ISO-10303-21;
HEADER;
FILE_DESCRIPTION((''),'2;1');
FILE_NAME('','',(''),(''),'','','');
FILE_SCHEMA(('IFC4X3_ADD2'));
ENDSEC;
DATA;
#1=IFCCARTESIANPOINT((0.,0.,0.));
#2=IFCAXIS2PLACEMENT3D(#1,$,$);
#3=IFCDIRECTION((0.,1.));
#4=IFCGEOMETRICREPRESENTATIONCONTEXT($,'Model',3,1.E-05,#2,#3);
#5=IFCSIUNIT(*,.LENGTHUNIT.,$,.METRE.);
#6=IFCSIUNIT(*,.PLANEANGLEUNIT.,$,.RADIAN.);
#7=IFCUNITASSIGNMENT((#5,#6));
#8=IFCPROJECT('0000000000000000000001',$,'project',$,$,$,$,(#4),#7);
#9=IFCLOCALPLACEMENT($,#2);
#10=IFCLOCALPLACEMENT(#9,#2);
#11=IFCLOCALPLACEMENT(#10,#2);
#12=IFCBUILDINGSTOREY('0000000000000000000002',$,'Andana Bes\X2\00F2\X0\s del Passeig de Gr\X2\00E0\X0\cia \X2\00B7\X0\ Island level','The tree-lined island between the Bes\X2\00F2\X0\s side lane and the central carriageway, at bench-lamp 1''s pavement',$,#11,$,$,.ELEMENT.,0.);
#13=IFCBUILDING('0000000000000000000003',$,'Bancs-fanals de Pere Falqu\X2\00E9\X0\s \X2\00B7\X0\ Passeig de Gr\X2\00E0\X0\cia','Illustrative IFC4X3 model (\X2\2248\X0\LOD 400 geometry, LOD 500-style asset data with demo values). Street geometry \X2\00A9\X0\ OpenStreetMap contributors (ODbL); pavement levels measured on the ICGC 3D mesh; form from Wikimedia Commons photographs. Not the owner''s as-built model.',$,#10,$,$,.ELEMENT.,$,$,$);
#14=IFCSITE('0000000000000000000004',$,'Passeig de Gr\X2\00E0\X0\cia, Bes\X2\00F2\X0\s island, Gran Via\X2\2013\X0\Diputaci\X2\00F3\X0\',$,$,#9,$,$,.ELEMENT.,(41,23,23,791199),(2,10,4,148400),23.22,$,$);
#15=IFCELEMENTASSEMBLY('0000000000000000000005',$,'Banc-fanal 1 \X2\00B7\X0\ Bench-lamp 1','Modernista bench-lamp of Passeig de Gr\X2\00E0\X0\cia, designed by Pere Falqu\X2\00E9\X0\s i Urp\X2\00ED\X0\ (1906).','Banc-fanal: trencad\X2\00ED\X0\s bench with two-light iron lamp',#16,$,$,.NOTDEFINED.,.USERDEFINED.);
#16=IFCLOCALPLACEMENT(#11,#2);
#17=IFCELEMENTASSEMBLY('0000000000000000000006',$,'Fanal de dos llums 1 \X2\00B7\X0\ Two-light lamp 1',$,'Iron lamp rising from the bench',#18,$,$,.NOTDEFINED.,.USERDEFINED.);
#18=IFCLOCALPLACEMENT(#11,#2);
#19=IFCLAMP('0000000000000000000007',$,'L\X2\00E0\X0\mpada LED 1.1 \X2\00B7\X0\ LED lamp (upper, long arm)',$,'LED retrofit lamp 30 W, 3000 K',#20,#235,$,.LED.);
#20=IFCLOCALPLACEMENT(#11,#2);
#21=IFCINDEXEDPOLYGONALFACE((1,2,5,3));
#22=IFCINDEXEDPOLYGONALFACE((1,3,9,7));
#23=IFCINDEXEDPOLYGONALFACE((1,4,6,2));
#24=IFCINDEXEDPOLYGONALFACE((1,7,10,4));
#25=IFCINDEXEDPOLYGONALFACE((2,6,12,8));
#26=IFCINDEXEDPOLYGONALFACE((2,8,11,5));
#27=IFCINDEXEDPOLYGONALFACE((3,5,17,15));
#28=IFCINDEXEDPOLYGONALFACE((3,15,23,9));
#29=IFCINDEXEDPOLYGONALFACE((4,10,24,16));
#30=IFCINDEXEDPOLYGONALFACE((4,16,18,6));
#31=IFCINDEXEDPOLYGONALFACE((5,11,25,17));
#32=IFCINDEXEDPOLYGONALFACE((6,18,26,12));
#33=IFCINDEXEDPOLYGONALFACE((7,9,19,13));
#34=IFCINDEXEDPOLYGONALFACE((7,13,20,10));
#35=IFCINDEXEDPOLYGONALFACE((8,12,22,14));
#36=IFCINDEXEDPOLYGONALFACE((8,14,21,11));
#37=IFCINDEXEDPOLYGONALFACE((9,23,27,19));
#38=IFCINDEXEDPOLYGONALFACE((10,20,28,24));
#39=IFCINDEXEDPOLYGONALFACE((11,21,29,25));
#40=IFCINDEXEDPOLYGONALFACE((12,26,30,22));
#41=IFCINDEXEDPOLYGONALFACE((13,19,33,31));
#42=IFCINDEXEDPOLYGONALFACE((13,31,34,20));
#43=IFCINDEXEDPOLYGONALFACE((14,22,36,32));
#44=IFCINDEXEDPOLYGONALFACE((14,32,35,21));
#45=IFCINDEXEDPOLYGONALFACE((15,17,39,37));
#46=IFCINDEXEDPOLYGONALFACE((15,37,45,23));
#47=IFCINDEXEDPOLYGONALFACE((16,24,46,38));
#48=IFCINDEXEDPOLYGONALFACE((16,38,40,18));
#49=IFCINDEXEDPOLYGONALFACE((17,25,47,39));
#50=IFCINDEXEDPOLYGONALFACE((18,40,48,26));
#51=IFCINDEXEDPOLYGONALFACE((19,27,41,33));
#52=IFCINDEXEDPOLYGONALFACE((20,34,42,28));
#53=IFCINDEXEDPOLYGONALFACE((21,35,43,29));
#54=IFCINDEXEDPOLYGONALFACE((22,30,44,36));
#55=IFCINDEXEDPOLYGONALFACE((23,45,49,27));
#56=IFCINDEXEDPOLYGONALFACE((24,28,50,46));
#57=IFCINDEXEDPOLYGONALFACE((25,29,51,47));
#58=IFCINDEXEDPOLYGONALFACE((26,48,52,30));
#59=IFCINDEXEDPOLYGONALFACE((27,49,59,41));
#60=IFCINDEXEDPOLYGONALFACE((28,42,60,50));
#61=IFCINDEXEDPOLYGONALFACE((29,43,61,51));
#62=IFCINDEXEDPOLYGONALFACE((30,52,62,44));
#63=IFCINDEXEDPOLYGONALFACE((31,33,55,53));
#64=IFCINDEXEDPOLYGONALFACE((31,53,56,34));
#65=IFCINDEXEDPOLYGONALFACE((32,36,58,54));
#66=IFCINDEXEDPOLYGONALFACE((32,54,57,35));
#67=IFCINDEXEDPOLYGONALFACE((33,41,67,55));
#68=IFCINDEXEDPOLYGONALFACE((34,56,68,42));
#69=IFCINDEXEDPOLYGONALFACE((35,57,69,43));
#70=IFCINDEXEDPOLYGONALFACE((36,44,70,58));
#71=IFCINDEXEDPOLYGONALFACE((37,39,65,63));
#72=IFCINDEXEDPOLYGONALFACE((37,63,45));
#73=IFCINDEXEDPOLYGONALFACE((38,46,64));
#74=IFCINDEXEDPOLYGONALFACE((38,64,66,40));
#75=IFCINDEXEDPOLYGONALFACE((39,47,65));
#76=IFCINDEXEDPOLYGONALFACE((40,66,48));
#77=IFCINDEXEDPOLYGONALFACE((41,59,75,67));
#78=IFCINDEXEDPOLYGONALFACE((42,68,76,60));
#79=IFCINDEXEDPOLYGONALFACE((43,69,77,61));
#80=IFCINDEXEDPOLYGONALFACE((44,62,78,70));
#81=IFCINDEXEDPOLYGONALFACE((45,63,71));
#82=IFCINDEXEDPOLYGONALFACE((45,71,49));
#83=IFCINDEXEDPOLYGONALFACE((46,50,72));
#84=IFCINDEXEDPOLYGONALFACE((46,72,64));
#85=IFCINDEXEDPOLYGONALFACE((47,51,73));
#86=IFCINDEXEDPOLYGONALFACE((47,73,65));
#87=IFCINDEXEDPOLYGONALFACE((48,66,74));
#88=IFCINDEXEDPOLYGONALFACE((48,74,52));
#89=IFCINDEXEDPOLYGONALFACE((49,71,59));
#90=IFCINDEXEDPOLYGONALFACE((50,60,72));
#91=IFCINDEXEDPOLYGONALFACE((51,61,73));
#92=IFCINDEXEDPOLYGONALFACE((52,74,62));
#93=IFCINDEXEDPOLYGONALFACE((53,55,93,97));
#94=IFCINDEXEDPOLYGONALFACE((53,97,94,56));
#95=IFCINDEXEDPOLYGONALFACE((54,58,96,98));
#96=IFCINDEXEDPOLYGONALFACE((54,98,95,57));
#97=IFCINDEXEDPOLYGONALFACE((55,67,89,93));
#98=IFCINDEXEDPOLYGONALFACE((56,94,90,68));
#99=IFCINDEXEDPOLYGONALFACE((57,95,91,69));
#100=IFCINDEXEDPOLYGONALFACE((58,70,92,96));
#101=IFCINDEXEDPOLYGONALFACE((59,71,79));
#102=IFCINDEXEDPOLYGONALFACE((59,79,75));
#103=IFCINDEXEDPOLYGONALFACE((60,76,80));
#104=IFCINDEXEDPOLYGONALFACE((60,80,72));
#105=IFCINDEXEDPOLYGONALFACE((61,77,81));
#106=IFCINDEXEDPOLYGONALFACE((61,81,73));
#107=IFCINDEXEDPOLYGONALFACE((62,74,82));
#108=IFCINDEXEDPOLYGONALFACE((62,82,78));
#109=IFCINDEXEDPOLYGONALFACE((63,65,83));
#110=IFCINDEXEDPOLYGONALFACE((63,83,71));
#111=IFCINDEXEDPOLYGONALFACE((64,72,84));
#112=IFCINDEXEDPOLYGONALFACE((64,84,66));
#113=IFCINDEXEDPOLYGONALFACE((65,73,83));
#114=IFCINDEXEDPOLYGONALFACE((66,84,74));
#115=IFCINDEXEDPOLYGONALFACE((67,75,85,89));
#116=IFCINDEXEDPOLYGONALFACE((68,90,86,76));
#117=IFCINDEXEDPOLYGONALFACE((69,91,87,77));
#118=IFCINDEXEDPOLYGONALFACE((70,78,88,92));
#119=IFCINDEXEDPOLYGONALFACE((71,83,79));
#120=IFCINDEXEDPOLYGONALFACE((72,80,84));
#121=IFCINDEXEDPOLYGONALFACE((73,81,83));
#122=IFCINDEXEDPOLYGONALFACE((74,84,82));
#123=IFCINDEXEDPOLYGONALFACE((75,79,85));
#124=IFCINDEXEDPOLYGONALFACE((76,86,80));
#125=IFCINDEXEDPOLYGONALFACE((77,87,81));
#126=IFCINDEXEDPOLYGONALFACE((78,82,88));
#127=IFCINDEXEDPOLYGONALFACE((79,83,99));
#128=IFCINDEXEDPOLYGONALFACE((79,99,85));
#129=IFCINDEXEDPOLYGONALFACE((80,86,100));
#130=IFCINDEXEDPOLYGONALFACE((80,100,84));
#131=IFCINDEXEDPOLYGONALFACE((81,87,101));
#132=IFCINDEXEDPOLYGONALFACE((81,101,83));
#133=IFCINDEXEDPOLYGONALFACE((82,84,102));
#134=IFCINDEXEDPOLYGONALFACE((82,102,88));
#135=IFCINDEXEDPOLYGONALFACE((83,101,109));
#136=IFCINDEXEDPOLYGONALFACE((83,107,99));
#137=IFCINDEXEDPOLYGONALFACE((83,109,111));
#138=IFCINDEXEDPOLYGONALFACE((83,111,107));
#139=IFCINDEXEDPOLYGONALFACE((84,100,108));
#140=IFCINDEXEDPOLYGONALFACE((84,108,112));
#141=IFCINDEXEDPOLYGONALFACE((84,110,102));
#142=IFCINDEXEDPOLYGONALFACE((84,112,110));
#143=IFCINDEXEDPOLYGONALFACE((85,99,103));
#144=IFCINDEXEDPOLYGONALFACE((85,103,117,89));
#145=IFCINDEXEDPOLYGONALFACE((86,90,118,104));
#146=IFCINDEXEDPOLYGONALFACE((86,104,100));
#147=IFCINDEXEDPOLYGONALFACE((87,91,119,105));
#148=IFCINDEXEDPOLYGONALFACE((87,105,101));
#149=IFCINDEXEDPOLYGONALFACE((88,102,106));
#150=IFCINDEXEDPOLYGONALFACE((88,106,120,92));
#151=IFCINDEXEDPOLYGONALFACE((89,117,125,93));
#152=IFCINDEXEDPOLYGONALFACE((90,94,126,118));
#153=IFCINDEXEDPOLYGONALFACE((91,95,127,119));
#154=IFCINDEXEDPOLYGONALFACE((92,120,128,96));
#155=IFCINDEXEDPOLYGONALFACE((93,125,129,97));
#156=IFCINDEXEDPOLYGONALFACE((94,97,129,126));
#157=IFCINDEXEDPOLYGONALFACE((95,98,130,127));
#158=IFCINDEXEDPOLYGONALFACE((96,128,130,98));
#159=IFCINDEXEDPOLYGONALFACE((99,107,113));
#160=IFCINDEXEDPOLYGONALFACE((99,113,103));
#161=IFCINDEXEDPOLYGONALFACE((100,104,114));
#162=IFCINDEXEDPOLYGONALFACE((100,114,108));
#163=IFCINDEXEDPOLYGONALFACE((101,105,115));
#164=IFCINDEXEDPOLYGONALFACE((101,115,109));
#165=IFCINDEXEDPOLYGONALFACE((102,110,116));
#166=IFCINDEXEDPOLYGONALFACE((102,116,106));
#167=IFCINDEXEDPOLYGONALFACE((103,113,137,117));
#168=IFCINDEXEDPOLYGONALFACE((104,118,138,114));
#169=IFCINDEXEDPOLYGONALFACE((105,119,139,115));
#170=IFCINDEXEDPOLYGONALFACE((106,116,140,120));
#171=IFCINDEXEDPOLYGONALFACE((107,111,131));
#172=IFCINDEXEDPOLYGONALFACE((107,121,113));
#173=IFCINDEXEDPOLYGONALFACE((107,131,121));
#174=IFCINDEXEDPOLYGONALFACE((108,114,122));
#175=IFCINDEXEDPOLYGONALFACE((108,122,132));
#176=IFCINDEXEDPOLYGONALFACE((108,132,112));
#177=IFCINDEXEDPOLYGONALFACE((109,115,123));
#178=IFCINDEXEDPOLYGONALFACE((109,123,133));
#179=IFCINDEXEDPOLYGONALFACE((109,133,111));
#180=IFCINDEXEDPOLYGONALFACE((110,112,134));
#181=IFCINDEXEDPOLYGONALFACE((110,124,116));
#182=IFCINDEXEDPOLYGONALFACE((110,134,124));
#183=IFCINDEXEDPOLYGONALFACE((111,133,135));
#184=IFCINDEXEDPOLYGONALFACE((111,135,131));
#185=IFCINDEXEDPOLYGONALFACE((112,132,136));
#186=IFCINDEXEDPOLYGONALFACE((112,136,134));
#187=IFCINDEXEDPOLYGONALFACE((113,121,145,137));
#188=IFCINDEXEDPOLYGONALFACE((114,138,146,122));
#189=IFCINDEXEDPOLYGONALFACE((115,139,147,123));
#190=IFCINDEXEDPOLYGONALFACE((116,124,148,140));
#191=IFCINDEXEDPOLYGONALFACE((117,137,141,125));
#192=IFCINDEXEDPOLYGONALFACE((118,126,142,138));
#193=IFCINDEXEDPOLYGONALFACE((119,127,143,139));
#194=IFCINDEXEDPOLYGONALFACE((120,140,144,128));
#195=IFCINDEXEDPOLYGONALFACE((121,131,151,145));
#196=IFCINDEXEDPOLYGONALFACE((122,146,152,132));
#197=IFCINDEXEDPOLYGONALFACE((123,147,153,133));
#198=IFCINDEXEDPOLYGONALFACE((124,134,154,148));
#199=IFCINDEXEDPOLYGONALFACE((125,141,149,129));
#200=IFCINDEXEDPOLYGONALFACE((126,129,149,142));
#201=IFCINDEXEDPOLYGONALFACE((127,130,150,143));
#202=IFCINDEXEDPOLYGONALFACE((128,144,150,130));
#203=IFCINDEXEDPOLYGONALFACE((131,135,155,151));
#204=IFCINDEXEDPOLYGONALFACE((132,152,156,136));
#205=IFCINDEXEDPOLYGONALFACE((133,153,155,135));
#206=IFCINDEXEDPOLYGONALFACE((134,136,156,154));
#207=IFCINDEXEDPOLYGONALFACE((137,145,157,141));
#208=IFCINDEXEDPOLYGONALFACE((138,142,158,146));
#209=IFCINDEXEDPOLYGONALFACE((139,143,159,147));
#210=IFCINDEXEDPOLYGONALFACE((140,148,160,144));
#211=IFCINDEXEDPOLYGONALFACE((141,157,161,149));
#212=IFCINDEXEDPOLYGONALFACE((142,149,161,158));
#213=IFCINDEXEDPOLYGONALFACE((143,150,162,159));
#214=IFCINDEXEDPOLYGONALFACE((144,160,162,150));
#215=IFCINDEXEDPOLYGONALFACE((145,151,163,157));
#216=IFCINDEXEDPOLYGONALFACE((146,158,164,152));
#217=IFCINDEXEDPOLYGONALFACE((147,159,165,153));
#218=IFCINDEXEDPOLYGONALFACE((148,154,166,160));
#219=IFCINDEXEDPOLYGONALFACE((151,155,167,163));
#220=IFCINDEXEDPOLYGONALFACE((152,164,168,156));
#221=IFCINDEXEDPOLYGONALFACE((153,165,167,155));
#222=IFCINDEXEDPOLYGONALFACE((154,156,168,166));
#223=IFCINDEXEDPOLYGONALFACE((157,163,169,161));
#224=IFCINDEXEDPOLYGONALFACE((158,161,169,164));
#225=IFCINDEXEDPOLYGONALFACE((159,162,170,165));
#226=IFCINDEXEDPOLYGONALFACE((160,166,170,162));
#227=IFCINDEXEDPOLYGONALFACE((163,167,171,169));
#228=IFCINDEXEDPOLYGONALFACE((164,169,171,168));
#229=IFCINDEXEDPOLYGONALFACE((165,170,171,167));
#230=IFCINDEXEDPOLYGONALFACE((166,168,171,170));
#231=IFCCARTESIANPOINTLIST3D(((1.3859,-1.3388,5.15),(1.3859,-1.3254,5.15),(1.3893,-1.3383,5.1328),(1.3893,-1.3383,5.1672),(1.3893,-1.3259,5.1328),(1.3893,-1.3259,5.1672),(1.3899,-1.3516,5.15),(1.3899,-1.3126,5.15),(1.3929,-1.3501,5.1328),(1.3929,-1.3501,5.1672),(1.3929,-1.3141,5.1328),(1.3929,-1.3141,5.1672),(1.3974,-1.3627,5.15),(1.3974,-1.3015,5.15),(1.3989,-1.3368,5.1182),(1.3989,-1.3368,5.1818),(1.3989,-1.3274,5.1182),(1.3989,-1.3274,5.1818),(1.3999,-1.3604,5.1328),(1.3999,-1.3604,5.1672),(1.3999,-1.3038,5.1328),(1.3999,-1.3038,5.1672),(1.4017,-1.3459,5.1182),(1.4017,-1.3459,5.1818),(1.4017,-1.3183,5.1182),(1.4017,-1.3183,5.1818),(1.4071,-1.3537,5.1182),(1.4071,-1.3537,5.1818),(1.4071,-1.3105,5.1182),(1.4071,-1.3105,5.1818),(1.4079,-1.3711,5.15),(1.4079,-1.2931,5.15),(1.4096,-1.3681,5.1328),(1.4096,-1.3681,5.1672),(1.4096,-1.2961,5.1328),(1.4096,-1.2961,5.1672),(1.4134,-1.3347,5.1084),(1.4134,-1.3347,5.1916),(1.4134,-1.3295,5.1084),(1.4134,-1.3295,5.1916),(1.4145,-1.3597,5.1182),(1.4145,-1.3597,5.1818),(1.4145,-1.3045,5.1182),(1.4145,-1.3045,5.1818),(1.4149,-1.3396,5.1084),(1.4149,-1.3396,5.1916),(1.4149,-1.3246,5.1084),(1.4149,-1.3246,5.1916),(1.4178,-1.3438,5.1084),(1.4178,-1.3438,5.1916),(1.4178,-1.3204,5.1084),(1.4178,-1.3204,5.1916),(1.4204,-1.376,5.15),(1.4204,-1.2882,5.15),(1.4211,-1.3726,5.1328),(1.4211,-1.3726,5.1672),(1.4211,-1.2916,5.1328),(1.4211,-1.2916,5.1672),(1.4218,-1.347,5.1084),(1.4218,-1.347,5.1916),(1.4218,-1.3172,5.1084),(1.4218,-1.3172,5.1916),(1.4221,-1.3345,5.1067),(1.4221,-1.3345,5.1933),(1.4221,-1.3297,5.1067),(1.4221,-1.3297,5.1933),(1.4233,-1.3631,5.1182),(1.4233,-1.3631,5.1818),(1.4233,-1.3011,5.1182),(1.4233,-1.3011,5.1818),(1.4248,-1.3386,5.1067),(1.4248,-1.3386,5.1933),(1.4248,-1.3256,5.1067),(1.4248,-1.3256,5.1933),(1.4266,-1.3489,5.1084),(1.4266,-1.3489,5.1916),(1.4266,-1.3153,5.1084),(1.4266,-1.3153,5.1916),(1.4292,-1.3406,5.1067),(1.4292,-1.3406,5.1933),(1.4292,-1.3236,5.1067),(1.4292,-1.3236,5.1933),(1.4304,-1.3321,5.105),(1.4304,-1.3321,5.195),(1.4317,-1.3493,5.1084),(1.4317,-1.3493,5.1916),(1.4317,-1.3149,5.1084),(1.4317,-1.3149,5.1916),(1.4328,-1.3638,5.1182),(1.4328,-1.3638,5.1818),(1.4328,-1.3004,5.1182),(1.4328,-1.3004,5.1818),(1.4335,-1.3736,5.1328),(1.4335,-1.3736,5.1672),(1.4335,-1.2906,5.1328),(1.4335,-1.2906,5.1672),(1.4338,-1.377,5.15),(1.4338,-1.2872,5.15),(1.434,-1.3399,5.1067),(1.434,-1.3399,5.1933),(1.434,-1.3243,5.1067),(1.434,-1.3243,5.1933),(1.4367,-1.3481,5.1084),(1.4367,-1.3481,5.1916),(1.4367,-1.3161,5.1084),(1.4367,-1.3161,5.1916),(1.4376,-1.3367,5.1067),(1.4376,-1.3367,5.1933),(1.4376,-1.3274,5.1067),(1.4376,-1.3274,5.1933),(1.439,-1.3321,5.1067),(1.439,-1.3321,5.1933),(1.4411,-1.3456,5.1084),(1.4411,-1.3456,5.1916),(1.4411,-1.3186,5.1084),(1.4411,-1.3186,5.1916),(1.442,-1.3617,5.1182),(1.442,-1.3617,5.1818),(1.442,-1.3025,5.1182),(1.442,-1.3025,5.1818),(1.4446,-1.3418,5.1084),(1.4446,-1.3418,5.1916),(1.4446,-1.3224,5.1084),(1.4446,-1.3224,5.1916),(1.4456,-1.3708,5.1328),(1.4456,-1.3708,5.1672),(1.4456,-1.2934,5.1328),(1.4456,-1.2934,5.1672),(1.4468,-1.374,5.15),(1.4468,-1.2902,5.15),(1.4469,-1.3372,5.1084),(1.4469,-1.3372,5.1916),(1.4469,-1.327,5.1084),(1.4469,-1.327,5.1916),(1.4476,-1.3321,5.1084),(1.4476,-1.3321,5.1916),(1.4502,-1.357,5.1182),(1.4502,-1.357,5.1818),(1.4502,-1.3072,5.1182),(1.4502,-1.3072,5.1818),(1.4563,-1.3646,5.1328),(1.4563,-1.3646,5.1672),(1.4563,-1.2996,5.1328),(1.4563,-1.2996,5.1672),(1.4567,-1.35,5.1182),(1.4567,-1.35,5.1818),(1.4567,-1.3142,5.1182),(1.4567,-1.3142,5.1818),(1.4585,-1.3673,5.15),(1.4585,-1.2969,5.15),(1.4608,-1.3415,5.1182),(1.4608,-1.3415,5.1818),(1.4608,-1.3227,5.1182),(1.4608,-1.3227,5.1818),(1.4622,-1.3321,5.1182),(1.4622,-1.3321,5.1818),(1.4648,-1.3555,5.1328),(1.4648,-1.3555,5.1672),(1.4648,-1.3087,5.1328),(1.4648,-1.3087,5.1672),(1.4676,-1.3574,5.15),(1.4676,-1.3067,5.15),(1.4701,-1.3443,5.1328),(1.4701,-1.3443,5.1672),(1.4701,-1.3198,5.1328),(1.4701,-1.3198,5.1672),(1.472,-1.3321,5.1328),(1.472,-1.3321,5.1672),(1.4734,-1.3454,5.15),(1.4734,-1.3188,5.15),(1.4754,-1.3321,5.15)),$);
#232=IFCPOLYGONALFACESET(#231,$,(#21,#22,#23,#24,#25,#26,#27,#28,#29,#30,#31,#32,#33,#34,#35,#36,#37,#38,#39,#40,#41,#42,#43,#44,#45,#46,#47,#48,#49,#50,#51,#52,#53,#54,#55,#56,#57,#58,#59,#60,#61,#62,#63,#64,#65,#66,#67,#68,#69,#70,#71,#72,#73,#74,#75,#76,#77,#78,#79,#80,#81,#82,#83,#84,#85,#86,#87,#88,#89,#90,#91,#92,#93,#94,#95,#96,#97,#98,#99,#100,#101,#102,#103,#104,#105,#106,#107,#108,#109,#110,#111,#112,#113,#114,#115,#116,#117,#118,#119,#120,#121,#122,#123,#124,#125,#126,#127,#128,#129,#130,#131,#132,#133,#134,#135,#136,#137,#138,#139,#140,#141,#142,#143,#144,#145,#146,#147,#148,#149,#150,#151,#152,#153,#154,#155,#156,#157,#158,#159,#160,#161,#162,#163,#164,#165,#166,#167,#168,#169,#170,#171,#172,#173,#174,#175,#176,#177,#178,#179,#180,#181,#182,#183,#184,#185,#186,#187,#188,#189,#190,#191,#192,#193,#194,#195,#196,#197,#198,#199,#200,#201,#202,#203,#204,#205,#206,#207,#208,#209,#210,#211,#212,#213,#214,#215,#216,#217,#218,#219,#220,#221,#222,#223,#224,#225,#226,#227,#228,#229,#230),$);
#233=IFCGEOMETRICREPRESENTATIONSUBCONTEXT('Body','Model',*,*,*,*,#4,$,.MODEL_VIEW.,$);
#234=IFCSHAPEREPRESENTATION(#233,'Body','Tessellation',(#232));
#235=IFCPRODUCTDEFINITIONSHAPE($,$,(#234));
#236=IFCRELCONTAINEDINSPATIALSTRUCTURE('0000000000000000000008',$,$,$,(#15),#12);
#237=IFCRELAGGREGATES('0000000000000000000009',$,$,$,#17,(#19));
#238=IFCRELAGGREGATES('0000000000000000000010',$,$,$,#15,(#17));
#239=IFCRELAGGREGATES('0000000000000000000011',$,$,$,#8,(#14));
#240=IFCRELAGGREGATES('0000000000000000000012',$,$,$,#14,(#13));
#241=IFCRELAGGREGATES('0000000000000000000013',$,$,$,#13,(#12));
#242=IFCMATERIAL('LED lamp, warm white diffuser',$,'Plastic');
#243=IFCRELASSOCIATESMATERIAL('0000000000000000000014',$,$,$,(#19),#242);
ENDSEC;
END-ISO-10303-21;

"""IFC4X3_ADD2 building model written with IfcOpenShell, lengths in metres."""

from ifc_helpers import new_model, entity, si_unit, direction, origin, place, context, subcontext, project, spatial, material, element, aggregate, save


model = new_model("IFC4X3_ADD2")

# Units and contexts
model_context = context("Model", 3, precision=1e-05, world=origin(), true_north=direction((0.0, 1.0)))
body_context = subcontext(model_context, "Body", "Model", "MODEL_VIEW")
ifc_project = project(units=[si_unit("LENGTHUNIT", "METRE"), si_unit("PLANEANGLEUNIT", "RADIAN")], contexts=[model_context])

# Site, building, storey
site_placement = place(None, origin())
site = spatial("IfcSite", under=ifc_project, at=site_placement, Name="Passeig de Gràcia, Besòs island, Gran Via–Diputació", CompositionType="ELEMENT", RefLatitude=(41, 23, 23, 791199), RefLongitude=(2, 10, 4, 148400), RefElevation=23.22)
building_placement = place(site_placement, origin())
building = spatial("IfcBuilding", under=site, at=building_placement, Name="Bancs-fanals de Pere Falqués · Passeig de Gràcia", Description="Illustrative IFC4X3 model (≈LOD 400 geometry, LOD 500-style asset data with demo values). Street geometry © OpenStreetMap contributors (ODbL); pavement levels measured on the ICGC 3D mesh; form from Wikimedia Commons photographs. Not the owner's as-built model.", CompositionType="ELEMENT")
storey_placement = place(building_placement, origin())
storey = spatial("IfcBuildingStorey", under=building, at=storey_placement, Name="Andana Besòs del Passeig de Gràcia · Island level", Description="The tree-lined island between the Besòs side lane and the central carriageway, at bench-lamp 1's pavement", CompositionType="ELEMENT", Elevation=0.0)

# Element assembly
assembly_1_placement = place(building_placement, origin())
assembly_1 = element("IfcElementAssembly", 1, at=assembly_1_placement, inside=storey, Name="Banc-fanal 1 · Bench-lamp 1", Description="Modernista bench-lamp of Passeig de Gràcia, designed by Pere Falqués i Urpí (1906).", ObjectType="Banc-fanal: trencadís bench with two-light iron lamp", AssemblyPlace="NOTDEFINED", PredefinedType="USERDEFINED")

# Element assembly
assembly_2_placement = place(building_placement, origin())
assembly_2 = element("IfcElementAssembly", 2, at=assembly_2_placement, Name="Fanal de dos llums 1 · Two-light lamp 1", ObjectType="Iron lamp rising from the bench", AssemblyPlace="NOTDEFINED", PredefinedType="USERDEFINED")

# Lamp
ifc_material_1 = material(Name="LED lamp, warm white diffuser", Category="Plastic")
lamp_1_placement = place(building_placement, origin())
lamp_1 = element("IfcLamp", 3, at=lamp_1_placement, material=ifc_material_1, Name="Làmpada LED 1.1 · LED lamp (upper, long arm)", ObjectType="LED retrofit lamp 30 W, 3000 K", PredefinedType="LED", context=body_context, shape_type="SweptSolid", body=[
    entity("IfcRevolvedAreaSolid", entity("IfcArbitraryClosedProfileDef", "AREA", None, entity("IfcPolyline", [entity("IfcCartesianPoint", [0.0, -0.045]), entity("IfcCartesianPoint", [0.0172, -0.0416]), entity("IfcCartesianPoint", [0.0318, -0.0318]), entity("IfcCartesianPoint", [0.0416, -0.0172]), entity("IfcCartesianPoint", [0.045, 0.0]), entity("IfcCartesianPoint", [0.0416, 0.0172]), entity("IfcCartesianPoint", [0.0318, 0.0318]), entity("IfcCartesianPoint", [0.0172, 0.0416]), entity("IfcCartesianPoint", [0.0, 0.045]), entity("IfcCartesianPoint", [0.0, -0.045])])), entity("IfcAxis2Placement3D", entity("IfcCartesianPoint", [1.4304, -1.3321, 5.15]), entity("IfcDirection", [0.0, -1.0, 0.0]), entity("IfcDirection", [1.0, 0.0, 0.0])), entity("IfcAxis1Placement", entity("IfcCartesianPoint", [0.0, 0.0, 0.0]), entity("IfcDirection", [0.0, 1.0, 0.0])), 6.283185),
])

aggregate(assembly_2, [lamp_1])

aggregate(assembly_1, [assembly_2])

save(model, "model.ifc")
